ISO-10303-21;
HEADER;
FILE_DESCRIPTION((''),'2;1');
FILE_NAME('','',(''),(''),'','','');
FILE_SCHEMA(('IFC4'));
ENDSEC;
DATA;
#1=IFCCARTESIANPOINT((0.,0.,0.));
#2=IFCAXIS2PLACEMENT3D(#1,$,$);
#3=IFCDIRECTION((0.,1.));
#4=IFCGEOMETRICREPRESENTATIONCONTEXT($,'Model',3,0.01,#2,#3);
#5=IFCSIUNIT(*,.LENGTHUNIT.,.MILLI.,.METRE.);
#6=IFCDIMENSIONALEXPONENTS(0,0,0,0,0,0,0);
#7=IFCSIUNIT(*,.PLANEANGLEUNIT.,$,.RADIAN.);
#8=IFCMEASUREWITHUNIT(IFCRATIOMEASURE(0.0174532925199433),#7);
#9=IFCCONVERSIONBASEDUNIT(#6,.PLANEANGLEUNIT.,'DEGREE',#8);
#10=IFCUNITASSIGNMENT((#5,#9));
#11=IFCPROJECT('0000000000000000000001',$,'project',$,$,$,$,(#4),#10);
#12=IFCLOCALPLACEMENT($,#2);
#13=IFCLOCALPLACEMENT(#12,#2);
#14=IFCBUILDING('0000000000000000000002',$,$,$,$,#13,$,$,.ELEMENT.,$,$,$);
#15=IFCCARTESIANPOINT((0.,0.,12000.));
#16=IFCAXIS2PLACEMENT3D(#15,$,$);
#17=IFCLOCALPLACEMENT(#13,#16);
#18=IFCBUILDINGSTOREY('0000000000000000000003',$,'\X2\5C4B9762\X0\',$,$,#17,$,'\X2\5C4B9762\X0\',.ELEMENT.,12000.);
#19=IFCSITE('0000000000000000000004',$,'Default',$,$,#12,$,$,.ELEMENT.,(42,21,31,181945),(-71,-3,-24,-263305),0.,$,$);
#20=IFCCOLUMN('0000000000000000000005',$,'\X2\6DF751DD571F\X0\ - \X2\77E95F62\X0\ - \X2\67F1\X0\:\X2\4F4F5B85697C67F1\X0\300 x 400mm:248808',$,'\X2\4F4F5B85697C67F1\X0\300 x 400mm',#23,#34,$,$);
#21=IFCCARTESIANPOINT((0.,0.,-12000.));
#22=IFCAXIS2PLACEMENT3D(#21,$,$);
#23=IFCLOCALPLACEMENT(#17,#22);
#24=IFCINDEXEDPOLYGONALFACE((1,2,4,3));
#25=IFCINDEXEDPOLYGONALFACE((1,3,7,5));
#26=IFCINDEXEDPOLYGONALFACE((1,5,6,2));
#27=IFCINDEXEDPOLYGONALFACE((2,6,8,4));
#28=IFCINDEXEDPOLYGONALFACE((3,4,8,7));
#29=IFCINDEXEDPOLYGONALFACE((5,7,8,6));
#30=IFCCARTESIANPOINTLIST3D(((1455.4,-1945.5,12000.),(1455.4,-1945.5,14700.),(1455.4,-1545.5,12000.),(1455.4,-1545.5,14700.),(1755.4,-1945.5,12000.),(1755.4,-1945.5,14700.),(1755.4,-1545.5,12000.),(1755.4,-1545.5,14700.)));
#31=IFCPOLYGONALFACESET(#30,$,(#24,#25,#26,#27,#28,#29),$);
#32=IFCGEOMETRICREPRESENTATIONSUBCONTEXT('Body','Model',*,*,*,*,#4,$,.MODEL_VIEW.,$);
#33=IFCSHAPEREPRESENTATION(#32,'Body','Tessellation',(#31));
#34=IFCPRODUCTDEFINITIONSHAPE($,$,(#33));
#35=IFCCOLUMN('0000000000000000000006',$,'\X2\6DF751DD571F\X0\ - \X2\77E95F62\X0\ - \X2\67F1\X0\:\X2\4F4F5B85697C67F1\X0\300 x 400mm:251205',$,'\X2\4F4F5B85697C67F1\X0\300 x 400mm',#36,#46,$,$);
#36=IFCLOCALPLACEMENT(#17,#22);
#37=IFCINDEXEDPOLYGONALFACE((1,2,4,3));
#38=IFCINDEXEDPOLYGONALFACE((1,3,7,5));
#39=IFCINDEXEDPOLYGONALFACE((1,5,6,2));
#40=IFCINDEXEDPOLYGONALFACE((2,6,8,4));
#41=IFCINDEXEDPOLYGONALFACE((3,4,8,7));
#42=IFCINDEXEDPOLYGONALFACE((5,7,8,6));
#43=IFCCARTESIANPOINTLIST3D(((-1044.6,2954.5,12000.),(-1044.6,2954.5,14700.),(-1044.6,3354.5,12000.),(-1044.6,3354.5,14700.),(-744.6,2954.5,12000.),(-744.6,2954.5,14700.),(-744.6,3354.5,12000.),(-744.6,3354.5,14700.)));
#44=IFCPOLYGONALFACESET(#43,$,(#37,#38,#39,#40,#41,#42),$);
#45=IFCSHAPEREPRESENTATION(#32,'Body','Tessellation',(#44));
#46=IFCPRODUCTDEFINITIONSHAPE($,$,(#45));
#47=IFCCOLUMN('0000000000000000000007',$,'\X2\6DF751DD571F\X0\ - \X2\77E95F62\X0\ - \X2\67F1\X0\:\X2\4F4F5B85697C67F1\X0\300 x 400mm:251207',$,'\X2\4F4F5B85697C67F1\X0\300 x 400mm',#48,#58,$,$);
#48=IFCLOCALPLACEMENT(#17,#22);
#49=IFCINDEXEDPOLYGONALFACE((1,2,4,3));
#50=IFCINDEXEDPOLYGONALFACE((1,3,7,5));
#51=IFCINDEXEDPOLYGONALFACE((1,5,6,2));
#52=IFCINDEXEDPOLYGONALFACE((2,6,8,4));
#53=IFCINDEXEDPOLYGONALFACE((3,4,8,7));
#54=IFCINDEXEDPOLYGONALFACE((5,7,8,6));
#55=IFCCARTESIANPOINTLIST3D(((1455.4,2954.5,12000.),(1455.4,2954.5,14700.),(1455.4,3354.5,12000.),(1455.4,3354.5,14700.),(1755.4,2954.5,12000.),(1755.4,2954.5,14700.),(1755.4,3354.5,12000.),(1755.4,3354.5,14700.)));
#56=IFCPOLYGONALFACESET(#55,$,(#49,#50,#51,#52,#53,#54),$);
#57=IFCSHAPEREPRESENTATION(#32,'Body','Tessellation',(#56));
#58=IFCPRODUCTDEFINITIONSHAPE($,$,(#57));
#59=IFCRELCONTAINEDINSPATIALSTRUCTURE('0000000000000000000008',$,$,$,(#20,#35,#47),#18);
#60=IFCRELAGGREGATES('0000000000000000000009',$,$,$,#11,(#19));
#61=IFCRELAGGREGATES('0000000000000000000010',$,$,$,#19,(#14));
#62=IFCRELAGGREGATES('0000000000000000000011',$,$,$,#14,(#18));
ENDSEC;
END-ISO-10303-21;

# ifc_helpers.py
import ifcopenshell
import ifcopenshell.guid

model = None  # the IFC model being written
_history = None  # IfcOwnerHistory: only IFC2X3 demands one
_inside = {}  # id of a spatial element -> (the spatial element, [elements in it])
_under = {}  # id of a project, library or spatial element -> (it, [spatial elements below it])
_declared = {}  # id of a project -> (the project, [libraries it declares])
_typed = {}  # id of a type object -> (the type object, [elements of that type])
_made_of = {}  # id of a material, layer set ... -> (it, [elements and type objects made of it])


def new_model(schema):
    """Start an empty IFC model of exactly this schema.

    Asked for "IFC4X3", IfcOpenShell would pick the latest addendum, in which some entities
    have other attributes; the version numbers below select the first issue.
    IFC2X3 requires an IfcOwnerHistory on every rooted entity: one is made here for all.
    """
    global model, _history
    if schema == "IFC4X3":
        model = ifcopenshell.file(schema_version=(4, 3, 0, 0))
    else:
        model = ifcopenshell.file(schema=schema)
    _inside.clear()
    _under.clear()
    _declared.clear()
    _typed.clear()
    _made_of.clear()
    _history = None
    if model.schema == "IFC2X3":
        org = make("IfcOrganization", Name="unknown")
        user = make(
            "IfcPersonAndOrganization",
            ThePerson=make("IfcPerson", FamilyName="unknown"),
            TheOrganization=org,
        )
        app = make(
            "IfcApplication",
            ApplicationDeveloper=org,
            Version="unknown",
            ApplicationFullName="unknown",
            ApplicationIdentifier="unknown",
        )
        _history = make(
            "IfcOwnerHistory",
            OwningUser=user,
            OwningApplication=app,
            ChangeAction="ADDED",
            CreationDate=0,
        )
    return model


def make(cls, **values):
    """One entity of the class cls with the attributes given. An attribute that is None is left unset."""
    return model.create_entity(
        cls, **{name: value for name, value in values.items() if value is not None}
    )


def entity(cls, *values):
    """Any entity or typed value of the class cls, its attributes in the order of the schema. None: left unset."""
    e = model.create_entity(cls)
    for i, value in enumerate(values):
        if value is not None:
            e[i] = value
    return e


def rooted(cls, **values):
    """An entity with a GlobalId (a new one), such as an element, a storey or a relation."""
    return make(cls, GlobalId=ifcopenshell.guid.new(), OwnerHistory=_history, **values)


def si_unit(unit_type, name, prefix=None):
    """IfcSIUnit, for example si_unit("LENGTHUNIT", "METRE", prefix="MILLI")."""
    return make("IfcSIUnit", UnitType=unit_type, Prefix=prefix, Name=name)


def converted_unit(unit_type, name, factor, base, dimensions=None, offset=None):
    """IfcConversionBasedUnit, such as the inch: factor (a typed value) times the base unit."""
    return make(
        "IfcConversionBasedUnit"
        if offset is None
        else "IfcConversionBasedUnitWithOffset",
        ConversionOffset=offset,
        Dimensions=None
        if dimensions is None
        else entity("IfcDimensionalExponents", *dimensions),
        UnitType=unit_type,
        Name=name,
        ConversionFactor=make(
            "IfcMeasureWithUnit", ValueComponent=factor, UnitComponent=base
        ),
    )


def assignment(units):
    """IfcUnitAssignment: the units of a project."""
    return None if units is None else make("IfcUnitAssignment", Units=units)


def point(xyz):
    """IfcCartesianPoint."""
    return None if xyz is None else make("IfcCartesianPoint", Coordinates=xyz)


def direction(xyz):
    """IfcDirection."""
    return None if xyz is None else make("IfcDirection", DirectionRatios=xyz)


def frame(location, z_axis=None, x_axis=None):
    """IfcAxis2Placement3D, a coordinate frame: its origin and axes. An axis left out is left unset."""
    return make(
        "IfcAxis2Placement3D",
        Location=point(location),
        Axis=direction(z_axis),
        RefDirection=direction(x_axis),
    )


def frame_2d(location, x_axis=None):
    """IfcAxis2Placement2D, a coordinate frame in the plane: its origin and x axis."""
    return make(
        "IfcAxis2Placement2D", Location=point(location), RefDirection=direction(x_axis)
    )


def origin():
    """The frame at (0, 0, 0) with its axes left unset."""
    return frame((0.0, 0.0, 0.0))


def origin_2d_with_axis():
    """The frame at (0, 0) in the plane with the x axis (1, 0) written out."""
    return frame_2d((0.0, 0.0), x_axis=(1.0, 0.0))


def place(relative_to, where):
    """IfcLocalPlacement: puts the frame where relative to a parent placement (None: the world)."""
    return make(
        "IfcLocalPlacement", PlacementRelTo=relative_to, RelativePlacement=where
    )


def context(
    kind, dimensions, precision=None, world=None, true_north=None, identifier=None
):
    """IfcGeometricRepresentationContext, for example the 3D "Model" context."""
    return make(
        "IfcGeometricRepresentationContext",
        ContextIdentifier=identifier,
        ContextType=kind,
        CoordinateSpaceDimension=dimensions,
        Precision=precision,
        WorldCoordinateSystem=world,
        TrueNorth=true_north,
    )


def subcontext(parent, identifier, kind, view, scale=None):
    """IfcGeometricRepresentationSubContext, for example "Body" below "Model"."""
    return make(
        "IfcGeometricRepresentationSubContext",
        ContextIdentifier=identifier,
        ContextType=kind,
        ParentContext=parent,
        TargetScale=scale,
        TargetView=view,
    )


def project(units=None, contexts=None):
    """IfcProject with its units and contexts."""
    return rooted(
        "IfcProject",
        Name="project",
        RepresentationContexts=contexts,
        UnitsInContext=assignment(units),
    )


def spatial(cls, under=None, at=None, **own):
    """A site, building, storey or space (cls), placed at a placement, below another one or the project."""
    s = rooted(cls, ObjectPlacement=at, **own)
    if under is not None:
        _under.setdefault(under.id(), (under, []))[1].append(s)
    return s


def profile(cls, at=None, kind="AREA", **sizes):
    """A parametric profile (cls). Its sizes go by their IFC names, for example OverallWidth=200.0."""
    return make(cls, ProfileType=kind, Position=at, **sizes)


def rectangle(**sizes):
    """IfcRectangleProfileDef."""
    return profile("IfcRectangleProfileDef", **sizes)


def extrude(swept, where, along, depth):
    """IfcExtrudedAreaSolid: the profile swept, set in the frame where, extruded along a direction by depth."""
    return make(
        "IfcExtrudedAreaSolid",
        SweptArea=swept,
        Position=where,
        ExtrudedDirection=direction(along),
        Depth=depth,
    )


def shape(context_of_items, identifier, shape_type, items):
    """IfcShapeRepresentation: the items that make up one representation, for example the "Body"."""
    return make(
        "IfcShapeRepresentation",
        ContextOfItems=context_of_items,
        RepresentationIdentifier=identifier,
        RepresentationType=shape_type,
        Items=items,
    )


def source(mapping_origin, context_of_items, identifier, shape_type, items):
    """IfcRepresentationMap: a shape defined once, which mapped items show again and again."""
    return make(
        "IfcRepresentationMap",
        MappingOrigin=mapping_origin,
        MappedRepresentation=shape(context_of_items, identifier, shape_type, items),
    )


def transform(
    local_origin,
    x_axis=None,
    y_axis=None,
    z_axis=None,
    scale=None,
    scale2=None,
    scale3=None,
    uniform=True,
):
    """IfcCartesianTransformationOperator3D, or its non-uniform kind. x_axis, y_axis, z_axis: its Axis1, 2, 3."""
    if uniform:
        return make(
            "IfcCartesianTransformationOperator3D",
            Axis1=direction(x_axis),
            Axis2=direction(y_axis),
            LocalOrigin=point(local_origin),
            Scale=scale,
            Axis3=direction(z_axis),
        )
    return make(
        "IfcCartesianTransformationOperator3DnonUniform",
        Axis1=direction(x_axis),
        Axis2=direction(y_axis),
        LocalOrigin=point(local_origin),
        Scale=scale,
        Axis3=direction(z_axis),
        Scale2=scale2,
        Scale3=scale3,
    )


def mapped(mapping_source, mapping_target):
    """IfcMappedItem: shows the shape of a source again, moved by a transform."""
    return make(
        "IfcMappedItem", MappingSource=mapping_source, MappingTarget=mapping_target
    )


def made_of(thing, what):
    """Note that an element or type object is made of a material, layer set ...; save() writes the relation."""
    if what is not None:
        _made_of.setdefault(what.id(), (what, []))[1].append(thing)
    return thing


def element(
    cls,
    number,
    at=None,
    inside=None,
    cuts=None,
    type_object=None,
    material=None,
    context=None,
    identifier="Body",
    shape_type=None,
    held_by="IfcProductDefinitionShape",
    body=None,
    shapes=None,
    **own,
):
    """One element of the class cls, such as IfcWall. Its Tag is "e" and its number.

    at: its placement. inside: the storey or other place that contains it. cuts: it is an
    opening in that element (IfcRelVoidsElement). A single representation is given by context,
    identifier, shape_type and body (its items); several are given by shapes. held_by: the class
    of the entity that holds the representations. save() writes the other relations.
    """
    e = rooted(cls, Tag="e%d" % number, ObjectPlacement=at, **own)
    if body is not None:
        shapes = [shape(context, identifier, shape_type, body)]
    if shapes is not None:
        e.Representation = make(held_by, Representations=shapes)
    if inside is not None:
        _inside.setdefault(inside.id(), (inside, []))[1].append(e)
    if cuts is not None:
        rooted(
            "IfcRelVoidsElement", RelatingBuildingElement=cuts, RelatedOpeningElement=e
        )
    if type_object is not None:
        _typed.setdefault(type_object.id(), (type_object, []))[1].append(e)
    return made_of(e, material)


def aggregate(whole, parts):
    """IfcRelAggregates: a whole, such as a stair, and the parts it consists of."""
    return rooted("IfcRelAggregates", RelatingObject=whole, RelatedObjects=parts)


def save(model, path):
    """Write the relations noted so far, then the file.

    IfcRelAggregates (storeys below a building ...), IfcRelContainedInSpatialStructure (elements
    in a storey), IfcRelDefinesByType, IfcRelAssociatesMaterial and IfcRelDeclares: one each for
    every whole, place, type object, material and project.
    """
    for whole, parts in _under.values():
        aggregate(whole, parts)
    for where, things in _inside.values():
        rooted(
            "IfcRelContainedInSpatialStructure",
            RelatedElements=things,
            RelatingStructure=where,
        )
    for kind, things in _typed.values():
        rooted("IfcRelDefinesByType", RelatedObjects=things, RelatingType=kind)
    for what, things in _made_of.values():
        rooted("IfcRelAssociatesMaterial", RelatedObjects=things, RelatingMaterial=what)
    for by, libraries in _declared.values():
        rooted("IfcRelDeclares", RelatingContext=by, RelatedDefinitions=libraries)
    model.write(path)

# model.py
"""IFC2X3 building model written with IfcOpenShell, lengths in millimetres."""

from ifc_helpers import new_model, entity, si_unit, converted_unit, direction, frame, frame_2d, origin, origin_2d_with_axis, place, context, subcontext, project, spatial, rectangle, extrude, source, transform, mapped, element, save


model = new_model("IFC2X3")

# Units and contexts
model_context = context("Model", 3, precision=0.01, world=origin(), true_north=direction((0.0, 1.0)))
body_context = subcontext(model_context, "Body", "Model", "MODEL_VIEW")
ifc_project = project(units=[si_unit("LENGTHUNIT", "METRE", prefix="MILLI"), converted_unit("PLANEANGLEUNIT", "DEGREE", entity("IfcRatioMeasure", 0.0174532925199433), si_unit("PLANEANGLEUNIT", "RADIAN"), dimensions=[0, 0, 0, 0, 0, 0, 0])], contexts=[model_context])

# Site, building, storey
site_placement = place(None, origin())
site = spatial("IfcSite", under=ifc_project, at=site_placement, Name="Default", CompositionType="ELEMENT", RefLatitude=(42, 21, 31, 181945), RefLongitude=(-71, -3, -24, -263305), RefElevation=0.0)
building_placement = place(site_placement, origin())
building = spatial("IfcBuilding", under=site, at=building_placement, CompositionType="ELEMENT")
storey_placement = place(building_placement, frame((0.0, 0.0, 12000.0)))
storey = spatial("IfcBuildingStorey", under=building, at=storey_placement, Name="屋面", LongName="屋面", CompositionType="ELEMENT", Elevation=12000.0)

# Columns
shared_shape_1 = source(origin(), body_context, "Body", "SweptSolid", [
    extrude(rectangle(XDim=400.0, YDim=300.0, at=origin_2d_with_axis()), frame((1605.4, -1745.5, 12000.0), z_axis=(0.0, 0.0, 1.0), x_axis=(0.0, -1.0, 0.0)), (0.0, 0.0, 1.0), 2700.0),
])
column_1_placement = place(storey_placement, frame((0.0, 0.0, -12000.0)))
element("IfcColumn", 1, at=column_1_placement, inside=storey, Name="混凝土 - 矩形 - 柱:住宅楼柱300 x 400mm:248808", ObjectType="住宅楼柱300 x 400mm", context=body_context, shape_type="MappedRepresentation", body=[
    mapped(shared_shape_1, transform((0.0, 0.0, 0.0), scale=1.0)),
])
shared_shape_2 = source(origin(), body_context, "Body", "SweptSolid", [
    extrude(rectangle(XDim=400.0, YDim=300.0, at=origin_2d_with_axis()), frame((-894.6, 3154.5, 12000.0), z_axis=(0.0, 0.0, 1.0), x_axis=(0.0, -1.0, 0.0)), (0.0, 0.0, 1.0), 2700.0),
])
column_2_placement = place(storey_placement, frame((0.0, 0.0, -12000.0)))
element("IfcColumn", 2, at=column_2_placement, inside=storey, Name="混凝土 - 矩形 - 柱:住宅楼柱300 x 400mm:251205", ObjectType="住宅楼柱300 x 400mm", context=body_context, shape_type="MappedRepresentation", body=[
    mapped(shared_shape_2, transform((0.0, 0.0, 0.0), scale=1.0)),
])
shared_shape_3 = source(origin(), body_context, "Body", "SweptSolid", [
    extrude(rectangle(XDim=400.0, YDim=300.0, at=frame_2d((0.0, 0.0), x_axis=(1.0, 0.0))), frame((1605.4, 3154.5, 12000.0), z_axis=(0.0, 0.0, 1.0), x_axis=(0.0, -1.0, 0.0)), (0.0, 0.0, 1.0), 2700.0),
])
column_3_placement = place(storey_placement, frame((0.0, 0.0, -12000.0)))
element("IfcColumn", 3, at=column_3_placement, inside=storey, Name="混凝土 - 矩形 - 柱:住宅楼柱300 x 400mm:251207", ObjectType="住宅楼柱300 x 400mm", context=body_context, shape_type="MappedRepresentation", body=[
    mapped(shared_shape_3, transform((0.0, 0.0, 0.0), scale=1.0)),
])

save(model, "model.ifc")
